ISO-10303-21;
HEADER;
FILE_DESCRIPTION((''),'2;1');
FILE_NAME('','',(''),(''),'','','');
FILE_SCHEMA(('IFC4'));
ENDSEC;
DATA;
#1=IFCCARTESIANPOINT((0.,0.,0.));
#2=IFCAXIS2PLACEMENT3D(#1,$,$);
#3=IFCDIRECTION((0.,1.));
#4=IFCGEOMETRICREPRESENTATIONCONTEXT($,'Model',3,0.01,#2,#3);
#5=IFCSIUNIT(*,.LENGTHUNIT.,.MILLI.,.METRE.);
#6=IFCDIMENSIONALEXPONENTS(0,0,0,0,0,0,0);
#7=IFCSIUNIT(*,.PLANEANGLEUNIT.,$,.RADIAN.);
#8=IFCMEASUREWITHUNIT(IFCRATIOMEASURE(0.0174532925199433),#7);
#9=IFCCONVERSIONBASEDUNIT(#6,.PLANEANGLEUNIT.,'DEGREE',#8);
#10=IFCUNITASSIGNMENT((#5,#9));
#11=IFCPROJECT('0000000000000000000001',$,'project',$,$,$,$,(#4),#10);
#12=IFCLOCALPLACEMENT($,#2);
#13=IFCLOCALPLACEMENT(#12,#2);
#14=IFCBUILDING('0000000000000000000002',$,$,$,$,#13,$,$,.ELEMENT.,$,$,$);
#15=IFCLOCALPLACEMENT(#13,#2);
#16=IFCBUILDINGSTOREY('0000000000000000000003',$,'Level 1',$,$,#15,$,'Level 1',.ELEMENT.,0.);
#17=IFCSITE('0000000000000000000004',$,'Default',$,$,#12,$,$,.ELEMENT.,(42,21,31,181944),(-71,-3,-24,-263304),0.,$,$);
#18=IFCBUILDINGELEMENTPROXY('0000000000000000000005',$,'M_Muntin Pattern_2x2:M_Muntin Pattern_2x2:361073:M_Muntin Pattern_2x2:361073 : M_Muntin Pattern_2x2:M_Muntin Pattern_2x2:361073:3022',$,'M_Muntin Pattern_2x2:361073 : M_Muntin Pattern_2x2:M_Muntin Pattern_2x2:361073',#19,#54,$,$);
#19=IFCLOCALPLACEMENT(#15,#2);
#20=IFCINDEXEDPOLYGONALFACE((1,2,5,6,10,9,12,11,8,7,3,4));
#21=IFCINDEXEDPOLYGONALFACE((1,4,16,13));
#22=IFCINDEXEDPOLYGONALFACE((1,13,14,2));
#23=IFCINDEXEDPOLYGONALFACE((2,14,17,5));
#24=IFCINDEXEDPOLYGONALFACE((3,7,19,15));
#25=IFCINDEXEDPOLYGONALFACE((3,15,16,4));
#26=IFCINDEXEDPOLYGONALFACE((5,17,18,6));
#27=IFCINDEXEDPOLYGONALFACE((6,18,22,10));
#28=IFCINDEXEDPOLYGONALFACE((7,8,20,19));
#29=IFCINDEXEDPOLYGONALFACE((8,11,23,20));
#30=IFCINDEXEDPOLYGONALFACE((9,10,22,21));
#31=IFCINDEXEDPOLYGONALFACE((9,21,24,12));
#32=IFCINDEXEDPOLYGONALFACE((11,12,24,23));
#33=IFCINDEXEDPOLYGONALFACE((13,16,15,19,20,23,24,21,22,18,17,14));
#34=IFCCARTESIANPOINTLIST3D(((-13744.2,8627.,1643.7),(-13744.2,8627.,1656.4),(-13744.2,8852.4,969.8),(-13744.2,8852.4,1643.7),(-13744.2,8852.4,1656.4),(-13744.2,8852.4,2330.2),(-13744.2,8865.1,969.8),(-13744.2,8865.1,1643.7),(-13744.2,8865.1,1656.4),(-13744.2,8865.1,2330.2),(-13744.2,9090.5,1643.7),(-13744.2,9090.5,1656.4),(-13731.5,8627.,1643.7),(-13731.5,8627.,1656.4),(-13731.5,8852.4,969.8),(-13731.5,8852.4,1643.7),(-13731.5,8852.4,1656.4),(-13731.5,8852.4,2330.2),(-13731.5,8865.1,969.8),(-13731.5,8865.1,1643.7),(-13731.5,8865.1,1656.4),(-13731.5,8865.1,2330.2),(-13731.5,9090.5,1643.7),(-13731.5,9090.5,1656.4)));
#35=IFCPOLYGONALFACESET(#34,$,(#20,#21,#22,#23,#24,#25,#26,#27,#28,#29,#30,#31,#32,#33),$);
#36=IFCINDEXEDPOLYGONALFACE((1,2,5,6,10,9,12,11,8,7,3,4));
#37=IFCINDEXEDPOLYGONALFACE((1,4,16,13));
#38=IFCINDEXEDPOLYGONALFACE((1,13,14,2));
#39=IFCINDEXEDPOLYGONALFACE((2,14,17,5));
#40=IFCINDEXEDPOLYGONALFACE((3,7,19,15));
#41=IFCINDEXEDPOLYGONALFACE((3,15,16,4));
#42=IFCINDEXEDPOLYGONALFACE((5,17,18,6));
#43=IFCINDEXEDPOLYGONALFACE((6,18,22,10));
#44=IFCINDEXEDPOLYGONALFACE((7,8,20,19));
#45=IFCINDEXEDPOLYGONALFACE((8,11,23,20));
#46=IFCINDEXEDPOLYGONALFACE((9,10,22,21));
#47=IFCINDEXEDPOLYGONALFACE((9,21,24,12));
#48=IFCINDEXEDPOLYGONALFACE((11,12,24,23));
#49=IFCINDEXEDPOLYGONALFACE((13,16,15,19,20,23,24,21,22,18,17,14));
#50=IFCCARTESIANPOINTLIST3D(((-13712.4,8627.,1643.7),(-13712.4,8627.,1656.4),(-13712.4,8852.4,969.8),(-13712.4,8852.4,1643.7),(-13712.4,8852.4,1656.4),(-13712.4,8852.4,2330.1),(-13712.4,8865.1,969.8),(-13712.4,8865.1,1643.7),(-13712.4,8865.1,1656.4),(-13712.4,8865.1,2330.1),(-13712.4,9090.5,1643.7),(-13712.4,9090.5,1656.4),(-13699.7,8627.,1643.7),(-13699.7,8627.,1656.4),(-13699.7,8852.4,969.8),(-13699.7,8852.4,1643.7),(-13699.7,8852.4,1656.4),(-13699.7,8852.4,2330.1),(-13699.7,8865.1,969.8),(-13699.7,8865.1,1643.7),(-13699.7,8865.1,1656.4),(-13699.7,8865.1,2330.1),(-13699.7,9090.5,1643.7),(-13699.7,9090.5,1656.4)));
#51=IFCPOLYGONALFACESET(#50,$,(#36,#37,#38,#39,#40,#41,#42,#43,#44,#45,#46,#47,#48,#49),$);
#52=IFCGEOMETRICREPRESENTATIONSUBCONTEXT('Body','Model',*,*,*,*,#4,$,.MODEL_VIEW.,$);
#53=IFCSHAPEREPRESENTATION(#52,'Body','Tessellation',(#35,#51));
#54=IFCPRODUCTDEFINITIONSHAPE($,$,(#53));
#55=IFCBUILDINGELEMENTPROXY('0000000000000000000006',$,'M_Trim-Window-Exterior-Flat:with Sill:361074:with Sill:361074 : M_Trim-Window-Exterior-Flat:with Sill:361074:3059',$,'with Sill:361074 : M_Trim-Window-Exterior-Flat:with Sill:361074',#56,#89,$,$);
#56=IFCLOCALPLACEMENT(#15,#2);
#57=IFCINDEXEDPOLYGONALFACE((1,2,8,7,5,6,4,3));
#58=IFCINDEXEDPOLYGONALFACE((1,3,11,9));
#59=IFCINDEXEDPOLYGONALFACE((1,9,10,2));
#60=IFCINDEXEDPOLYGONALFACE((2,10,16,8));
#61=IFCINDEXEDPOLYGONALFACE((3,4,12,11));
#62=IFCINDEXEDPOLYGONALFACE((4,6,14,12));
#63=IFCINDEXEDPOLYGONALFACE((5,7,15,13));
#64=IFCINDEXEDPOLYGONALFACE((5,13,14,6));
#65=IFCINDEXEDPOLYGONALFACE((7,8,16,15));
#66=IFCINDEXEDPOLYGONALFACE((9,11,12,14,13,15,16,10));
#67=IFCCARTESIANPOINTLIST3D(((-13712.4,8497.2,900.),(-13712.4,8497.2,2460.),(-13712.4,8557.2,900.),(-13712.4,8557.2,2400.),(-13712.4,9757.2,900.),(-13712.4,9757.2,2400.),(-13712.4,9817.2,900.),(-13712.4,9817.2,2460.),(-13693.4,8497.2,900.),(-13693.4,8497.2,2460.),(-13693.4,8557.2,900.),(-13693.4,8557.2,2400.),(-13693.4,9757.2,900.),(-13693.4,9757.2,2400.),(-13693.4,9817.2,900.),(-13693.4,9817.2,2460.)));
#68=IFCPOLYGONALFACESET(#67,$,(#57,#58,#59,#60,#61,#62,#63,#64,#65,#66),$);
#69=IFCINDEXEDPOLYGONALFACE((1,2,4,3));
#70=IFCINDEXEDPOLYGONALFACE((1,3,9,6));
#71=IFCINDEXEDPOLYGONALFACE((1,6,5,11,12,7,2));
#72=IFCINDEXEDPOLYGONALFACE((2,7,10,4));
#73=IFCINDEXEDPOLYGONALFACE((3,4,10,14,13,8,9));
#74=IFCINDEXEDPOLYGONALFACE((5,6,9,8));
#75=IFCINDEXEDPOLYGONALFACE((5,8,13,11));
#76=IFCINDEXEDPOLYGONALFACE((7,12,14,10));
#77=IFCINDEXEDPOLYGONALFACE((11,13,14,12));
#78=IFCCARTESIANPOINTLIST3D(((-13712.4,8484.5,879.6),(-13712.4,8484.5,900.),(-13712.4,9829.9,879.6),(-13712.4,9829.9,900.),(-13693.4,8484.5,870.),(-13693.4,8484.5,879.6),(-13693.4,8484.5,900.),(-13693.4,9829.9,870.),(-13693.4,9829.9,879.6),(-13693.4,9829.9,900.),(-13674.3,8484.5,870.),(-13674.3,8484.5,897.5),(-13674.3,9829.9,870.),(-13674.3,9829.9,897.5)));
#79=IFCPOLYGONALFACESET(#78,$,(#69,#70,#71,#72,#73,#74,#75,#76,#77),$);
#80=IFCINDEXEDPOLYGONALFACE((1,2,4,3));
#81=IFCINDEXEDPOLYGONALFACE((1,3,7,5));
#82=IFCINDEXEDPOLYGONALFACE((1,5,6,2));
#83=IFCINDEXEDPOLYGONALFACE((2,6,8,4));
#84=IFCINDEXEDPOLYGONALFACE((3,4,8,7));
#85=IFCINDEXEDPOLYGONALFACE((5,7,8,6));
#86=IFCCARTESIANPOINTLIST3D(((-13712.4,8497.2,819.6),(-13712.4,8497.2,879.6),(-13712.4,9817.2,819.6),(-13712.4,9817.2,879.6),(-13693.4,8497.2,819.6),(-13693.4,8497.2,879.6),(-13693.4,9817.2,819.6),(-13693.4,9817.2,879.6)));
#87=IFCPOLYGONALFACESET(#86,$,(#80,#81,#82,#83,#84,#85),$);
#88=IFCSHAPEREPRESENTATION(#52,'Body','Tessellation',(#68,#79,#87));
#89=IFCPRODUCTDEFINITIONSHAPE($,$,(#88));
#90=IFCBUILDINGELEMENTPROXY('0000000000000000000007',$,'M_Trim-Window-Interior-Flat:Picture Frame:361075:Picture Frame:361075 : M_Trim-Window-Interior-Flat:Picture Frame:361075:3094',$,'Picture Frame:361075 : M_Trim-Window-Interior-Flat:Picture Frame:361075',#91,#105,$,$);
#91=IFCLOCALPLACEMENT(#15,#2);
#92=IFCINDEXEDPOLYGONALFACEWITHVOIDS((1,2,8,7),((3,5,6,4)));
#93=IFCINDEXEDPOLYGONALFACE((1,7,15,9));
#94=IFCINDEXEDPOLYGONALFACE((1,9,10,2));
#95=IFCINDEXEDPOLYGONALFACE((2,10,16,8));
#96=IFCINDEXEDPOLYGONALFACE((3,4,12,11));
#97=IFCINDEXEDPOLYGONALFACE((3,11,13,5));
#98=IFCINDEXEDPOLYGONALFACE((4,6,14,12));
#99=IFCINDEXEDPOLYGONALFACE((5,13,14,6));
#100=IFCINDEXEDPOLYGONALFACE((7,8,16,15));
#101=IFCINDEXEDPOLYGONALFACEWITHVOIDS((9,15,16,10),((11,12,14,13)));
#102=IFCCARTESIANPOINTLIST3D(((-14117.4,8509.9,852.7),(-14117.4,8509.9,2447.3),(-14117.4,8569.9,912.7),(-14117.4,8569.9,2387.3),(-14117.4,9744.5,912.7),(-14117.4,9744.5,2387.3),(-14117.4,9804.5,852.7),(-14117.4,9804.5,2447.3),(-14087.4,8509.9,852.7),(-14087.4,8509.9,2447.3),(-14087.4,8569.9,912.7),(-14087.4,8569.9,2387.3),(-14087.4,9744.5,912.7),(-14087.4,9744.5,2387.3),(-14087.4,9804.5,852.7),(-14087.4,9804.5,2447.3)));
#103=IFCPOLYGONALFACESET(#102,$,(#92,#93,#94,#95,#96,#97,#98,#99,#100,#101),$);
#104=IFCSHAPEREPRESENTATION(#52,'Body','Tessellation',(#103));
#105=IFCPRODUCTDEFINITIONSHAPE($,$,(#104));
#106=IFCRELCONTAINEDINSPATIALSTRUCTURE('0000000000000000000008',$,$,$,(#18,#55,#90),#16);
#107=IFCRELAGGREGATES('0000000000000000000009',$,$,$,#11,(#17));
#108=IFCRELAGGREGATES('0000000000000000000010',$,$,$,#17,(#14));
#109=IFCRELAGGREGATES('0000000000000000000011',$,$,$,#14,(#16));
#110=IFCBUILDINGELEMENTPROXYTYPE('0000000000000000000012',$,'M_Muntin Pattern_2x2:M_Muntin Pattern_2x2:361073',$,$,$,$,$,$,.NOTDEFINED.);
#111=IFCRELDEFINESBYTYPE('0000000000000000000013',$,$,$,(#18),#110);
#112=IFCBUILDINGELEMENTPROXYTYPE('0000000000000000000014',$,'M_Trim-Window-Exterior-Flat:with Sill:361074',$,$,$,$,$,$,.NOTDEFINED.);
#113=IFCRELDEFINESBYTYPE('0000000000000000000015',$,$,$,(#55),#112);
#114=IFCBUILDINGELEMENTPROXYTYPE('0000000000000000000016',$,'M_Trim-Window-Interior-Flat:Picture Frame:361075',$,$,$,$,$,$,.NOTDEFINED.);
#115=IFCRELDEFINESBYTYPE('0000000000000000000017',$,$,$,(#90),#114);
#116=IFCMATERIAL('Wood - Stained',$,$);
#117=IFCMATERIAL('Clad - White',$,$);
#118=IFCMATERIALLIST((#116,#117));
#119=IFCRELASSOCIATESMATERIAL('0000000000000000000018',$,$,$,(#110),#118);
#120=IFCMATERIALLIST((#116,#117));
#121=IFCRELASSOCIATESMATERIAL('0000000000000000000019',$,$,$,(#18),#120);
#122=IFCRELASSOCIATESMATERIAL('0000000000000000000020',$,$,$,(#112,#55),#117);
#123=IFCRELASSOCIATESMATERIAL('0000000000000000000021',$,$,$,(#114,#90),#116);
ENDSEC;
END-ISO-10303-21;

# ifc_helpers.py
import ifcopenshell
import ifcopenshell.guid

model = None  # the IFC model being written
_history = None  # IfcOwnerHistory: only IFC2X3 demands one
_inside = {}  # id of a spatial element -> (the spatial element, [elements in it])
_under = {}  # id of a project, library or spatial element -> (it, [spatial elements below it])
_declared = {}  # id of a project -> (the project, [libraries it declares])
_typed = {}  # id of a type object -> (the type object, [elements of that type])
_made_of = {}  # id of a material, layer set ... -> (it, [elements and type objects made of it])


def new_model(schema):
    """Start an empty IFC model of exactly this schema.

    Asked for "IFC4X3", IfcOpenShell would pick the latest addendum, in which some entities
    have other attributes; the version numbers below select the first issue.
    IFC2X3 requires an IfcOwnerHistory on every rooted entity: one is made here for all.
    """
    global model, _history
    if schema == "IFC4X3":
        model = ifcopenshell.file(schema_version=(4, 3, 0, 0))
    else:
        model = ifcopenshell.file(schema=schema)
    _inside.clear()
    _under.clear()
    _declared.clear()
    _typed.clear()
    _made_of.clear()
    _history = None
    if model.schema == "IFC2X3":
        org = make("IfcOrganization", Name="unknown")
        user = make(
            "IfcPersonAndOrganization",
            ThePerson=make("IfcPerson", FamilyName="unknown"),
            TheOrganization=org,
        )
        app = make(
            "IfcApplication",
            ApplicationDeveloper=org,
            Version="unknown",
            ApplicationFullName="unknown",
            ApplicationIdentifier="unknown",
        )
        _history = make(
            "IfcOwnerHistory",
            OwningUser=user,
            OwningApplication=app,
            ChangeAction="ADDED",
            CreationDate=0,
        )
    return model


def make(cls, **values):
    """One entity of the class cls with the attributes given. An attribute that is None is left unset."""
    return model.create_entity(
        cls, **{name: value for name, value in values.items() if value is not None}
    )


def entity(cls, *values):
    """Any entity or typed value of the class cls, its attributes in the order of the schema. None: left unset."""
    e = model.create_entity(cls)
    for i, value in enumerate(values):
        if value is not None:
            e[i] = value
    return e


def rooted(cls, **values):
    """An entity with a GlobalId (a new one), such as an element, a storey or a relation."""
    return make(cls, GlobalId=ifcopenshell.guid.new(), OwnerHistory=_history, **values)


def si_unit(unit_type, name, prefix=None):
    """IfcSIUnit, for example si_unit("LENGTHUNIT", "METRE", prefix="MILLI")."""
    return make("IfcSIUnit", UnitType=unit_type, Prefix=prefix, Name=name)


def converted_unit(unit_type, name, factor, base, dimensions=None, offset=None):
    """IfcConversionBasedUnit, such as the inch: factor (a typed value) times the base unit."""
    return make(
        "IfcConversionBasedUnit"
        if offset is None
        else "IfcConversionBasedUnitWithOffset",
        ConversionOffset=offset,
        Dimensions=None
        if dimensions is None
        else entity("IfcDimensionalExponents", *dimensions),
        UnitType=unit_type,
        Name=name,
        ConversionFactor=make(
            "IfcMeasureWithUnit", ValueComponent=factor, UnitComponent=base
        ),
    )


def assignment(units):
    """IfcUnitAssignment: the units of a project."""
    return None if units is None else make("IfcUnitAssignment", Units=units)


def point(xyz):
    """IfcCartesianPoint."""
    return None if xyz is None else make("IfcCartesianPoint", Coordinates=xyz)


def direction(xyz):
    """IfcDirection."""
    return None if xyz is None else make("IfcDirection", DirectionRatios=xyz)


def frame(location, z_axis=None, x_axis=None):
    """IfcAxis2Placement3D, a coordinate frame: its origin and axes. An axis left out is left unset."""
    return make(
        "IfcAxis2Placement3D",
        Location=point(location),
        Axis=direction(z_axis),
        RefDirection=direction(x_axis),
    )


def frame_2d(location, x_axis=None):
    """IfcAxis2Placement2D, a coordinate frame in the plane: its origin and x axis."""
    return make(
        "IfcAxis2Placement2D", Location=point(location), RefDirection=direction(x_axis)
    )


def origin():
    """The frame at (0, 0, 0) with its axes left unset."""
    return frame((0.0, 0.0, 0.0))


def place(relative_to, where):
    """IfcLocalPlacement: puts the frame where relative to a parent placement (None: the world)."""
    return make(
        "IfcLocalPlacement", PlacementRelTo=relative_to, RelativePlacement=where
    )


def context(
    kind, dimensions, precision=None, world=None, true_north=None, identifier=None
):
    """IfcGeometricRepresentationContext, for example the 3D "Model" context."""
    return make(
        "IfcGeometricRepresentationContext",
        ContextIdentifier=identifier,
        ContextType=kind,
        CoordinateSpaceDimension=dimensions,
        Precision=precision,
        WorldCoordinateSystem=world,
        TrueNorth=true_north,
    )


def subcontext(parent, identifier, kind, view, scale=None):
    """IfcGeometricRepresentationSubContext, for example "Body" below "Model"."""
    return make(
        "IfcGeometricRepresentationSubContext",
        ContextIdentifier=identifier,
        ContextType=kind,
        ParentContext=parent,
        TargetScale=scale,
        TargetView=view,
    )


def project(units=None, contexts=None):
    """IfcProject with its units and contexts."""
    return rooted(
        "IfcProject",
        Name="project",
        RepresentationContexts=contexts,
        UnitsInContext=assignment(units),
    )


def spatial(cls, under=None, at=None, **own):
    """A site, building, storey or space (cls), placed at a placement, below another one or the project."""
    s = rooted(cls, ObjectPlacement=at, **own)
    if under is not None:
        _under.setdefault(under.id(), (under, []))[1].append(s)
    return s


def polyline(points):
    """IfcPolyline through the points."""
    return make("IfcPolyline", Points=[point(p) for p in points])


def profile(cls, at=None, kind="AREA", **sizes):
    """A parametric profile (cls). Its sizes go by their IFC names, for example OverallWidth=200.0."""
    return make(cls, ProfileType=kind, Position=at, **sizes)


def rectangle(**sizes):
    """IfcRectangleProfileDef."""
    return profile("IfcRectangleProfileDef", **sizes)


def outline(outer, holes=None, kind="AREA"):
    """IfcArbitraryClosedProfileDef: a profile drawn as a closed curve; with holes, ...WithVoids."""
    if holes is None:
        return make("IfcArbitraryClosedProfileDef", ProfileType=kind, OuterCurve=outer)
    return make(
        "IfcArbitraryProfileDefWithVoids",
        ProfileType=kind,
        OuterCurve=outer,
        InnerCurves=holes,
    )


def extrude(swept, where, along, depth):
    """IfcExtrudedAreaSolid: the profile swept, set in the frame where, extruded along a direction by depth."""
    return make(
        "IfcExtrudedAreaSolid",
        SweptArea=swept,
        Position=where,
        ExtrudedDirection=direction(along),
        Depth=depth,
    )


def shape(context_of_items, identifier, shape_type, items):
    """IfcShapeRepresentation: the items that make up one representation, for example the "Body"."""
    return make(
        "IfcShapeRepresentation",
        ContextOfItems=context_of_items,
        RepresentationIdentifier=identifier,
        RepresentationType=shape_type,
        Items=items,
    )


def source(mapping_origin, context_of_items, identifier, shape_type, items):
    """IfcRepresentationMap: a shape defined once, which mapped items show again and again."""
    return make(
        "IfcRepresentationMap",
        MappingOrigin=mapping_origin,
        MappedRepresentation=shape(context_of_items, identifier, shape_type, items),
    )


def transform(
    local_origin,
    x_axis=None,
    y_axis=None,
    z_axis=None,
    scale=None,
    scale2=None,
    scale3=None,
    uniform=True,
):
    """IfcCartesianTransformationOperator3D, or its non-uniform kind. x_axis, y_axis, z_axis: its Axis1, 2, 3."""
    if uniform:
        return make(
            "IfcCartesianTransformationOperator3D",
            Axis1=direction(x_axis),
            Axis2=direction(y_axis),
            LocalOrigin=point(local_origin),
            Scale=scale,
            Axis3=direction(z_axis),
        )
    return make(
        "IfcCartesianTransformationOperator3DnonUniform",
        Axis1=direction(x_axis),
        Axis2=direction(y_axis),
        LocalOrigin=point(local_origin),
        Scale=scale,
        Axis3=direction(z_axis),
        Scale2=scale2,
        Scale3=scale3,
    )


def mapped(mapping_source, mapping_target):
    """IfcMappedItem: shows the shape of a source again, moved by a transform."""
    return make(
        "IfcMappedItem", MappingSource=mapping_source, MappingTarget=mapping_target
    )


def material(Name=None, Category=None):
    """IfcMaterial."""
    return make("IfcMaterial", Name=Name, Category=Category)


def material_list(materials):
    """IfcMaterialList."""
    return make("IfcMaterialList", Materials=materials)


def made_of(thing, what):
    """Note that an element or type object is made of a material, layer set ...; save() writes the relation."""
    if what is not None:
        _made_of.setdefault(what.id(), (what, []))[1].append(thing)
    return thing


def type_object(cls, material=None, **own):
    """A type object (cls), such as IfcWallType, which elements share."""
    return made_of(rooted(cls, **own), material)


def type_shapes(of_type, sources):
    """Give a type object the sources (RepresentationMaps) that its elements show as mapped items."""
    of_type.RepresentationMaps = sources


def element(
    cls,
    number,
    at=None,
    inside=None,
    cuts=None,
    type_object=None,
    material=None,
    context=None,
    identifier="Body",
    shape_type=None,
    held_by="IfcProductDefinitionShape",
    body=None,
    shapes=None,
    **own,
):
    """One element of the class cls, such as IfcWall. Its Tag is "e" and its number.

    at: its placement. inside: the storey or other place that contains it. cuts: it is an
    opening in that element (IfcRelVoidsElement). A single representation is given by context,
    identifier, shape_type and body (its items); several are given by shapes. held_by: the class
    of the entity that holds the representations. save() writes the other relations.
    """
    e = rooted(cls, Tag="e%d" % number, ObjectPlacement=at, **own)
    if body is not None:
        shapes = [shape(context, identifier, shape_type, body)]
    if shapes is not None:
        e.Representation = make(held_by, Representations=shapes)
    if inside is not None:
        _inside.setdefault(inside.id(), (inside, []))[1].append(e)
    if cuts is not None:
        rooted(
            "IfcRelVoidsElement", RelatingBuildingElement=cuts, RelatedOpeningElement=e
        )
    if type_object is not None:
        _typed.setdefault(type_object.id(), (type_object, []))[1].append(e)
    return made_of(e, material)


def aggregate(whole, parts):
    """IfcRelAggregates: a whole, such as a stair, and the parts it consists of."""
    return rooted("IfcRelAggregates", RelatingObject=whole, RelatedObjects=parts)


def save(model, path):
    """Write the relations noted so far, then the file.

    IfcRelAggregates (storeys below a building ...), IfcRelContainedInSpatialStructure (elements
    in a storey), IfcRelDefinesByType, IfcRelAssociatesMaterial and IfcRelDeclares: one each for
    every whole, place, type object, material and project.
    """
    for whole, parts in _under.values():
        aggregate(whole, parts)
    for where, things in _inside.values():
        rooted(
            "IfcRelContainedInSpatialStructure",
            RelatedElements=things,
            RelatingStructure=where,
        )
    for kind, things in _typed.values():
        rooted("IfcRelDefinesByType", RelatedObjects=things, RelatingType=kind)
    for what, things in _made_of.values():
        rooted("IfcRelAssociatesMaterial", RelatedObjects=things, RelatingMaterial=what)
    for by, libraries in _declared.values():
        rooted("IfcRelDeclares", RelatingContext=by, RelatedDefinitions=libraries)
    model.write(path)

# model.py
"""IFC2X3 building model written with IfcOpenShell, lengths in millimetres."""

from ifc_helpers import new_model, entity, si_unit, converted_unit, direction, frame, frame_2d, origin, place, context, subcontext, project, spatial, polyline, rectangle, outline, extrude, source, transform, mapped, material, material_list, type_object, type_shapes, element, save


model = new_model("IFC2X3")

# Units and contexts
model_context = context("Model", 3, precision=0.01, world=origin(), true_north=direction((0.0, 1.0)))
body_context = subcontext(model_context, "Body", "Model", "MODEL_VIEW")
ifc_project = project(units=[si_unit("LENGTHUNIT", "METRE", prefix="MILLI"), converted_unit("PLANEANGLEUNIT", "DEGREE", entity("IfcRatioMeasure", 0.0174532925199433), si_unit("PLANEANGLEUNIT", "RADIAN"), dimensions=[0, 0, 0, 0, 0, 0, 0])], contexts=[model_context])

# Site, building, storey
site_placement = place(None, origin())
site = spatial("IfcSite", under=ifc_project, at=site_placement, Name="Default", CompositionType="ELEMENT", RefLatitude=(42, 21, 31, 181944), RefLongitude=(-71, -3, -24, -263304), RefElevation=0.0)
building_placement = place(site_placement, origin())
building = spatial("IfcBuilding", under=site, at=building_placement, CompositionType="ELEMENT")
storey_placement = place(building_placement, origin())
storey = spatial("IfcBuildingStorey", under=building, at=storey_placement, Name="Level 1", LongName="Level 1", CompositionType="ELEMENT", Elevation=0.0)

# Building element proxies
ifc_material_1 = material(Name="Clad - White")
ifc_material_2 = material(Name="Wood - Stained")
ifc_material_list_1 = material_list([ifc_material_2, ifc_material_1])
ifc_material_list_2 = material_list([ifc_material_2, ifc_material_1])
building_element_proxy_type_1 = type_object("IfcBuildingElementProxyType", Name="M_Muntin Pattern_2x2:M_Muntin Pattern_2x2:361073", PredefinedType="NOTDEFINED", material=ifc_material_list_2)
shared_shape_1 = source(origin(), body_context, "Body", "SweptSolid", [
    extrude(outline(polyline([(-680.1, 6.4), (-680.1, -6.3), (-6.4, -6.3), (-6.4, -231.7), (6.3, -231.7), (6.3, -6.3), (680.2, -6.3), (680.2, 6.4), (6.3, 6.4), (6.3, 231.7), (-6.4, 231.7), (-6.4, 6.4), (-680.1, 6.4)])), frame((-13744.2, 8858.7, 1650.0), z_axis=(-1.0, 0.0, 0.0), x_axis=(0.0, 0.0, -1.0)), (0.0, 0.0, -1.0), 12.7),
    extrude(outline(polyline([(-680.1, 6.4), (-680.1, -6.3), (-6.4, -6.3), (-6.4, -231.7), (6.3, -231.7), (6.3, -6.3), (680.2, -6.3), (680.2, 6.4), (6.3, 6.4), (6.3, 231.7), (-6.4, 231.7), (-6.4, 6.4), (-680.1, 6.4)])), frame((-13712.4, 8858.7, 1650.0), z_axis=(-1.0, 0.0, 0.0), x_axis=(0.0, 0.0, -1.0)), (0.0, 0.0, -1.0), 12.7),
])
type_shapes(building_element_proxy_type_1, [shared_shape_1])
proxy_1_placement = place(storey_placement, origin())
element("IfcBuildingElementProxy", 1, at=proxy_1_placement, inside=storey, type_object=building_element_proxy_type_1, material=ifc_material_list_1, Name="M_Muntin Pattern_2x2:M_Muntin Pattern_2x2:361073:M_Muntin Pattern_2x2:361073 : M_Muntin Pattern_2x2:M_Muntin Pattern_2x2:361073:3022", ObjectType="M_Muntin Pattern_2x2:361073 : M_Muntin Pattern_2x2:M_Muntin Pattern_2x2:361073", context=body_context, shape_type="MappedRepresentation", body=[
    mapped(shared_shape_1, transform((0.0, 0.0, 0.0), scale=1.0)),
])
building_element_proxy_type_2 = type_object("IfcBuildingElementProxyType", Name="M_Trim-Window-Exterior-Flat:with Sill:361074", PredefinedType="NOTDEFINED", material=ifc_material_1)
shared_shape_2 = source(origin(), body_context, "Body", "SweptSolid", [
    extrude(outline(polyline([(-660.0, -765.0), (-600.0, -765.0), (-600.0, 735.0), (600.0, 735.0), (600.0, -765.0), (660.0, -765.0), (660.0, 795.0), (-660.0, 795.0), (-660.0, -765.0)])), frame((-13712.4, 9157.2, 1665.0), z_axis=(1.0, 0.0, 0.0), x_axis=(0.0, 1.0, 0.0)), (0.0, 0.0, 1.0), 19.1),
    extrude(outline(polyline([(-15.2, 0.0), (-15.2, -19.0), (12.3, -19.0), (14.8, 0.0), (14.8, 19.0), (-5.7, 19.0), (-5.7, 0.0), (-15.2, 0.0)])), frame((-13693.4, 8484.5, 885.2), z_axis=(0.0, -1.0, 0.0), x_axis=(0.0, 0.0, 1.0)), (0.0, 0.0, -1.0), 1345.4),
    extrude(rectangle(XDim=19.1, YDim=1320.0, at=frame_2d((0.0, 0.0), x_axis=(1.0, 0.0))), frame((-13702.9, 9157.2, 819.6), z_axis=(0.0, 0.0, 1.0), x_axis=(-1.0, 0.0, 0.0)), (0.0, 0.0, 1.0), 60.0),
])
type_shapes(building_element_proxy_type_2, [shared_shape_2])
proxy_2_placement = place(storey_placement, origin())
element("IfcBuildingElementProxy", 2, at=proxy_2_placement, inside=storey, type_object=building_element_proxy_type_2, material=ifc_material_1, Name="M_Trim-Window-Exterior-Flat:with Sill:361074:with Sill:361074 : M_Trim-Window-Exterior-Flat:with Sill:361074:3059", ObjectType="with Sill:361074 : M_Trim-Window-Exterior-Flat:with Sill:361074", context=body_context, shape_type="MappedRepresentation", body=[
    mapped(shared_shape_2, transform((0.0, 0.0, 0.0), scale=1.0)),
])
building_element_proxy_type_3 = type_object("IfcBuildingElementProxyType", Name="M_Trim-Window-Interior-Flat:Picture Frame:361075", PredefinedType="NOTDEFINED", material=ifc_material_2)
shared_shape_3 = source(origin(), body_context, "Body", "SweptSolid", [
    extrude(outline(polyline([(-647.3, -797.3), (647.3, -797.3), (647.3, 797.3), (-647.3, 797.3), (-647.3, -797.3)]), holes=[polyline([(587.3, 737.3), (587.3, -737.3), (-587.3, -737.3), (-587.3, 737.3), (587.3, 737.3)])]), frame((-14117.4, 9157.2, 1650.0), z_axis=(1.0, 0.0, 0.0), x_axis=(0.0, -1.0, 0.0)), (0.0, 0.0, 1.0), 30.0),
])
type_shapes(building_element_proxy_type_3, [shared_shape_3])
proxy_3_placement = place(storey_placement, origin())
element("IfcBuildingElementProxy", 3, at=proxy_3_placement, inside=storey, type_object=building_element_proxy_type_3, material=ifc_material_2, Name="M_Trim-Window-Interior-Flat:Picture Frame:361075:Picture Frame:361075 : M_Trim-Window-Interior-Flat:Picture Frame:361075:3094", ObjectType="Picture Frame:361075 : M_Trim-Window-Interior-Flat:Picture Frame:361075", context=body_context, shape_type="MappedRepresentation", body=[
    mapped(shared_shape_3, transform((0.0, 0.0, 0.0), scale=1.0)),
])

save(model, "model.ifc")
